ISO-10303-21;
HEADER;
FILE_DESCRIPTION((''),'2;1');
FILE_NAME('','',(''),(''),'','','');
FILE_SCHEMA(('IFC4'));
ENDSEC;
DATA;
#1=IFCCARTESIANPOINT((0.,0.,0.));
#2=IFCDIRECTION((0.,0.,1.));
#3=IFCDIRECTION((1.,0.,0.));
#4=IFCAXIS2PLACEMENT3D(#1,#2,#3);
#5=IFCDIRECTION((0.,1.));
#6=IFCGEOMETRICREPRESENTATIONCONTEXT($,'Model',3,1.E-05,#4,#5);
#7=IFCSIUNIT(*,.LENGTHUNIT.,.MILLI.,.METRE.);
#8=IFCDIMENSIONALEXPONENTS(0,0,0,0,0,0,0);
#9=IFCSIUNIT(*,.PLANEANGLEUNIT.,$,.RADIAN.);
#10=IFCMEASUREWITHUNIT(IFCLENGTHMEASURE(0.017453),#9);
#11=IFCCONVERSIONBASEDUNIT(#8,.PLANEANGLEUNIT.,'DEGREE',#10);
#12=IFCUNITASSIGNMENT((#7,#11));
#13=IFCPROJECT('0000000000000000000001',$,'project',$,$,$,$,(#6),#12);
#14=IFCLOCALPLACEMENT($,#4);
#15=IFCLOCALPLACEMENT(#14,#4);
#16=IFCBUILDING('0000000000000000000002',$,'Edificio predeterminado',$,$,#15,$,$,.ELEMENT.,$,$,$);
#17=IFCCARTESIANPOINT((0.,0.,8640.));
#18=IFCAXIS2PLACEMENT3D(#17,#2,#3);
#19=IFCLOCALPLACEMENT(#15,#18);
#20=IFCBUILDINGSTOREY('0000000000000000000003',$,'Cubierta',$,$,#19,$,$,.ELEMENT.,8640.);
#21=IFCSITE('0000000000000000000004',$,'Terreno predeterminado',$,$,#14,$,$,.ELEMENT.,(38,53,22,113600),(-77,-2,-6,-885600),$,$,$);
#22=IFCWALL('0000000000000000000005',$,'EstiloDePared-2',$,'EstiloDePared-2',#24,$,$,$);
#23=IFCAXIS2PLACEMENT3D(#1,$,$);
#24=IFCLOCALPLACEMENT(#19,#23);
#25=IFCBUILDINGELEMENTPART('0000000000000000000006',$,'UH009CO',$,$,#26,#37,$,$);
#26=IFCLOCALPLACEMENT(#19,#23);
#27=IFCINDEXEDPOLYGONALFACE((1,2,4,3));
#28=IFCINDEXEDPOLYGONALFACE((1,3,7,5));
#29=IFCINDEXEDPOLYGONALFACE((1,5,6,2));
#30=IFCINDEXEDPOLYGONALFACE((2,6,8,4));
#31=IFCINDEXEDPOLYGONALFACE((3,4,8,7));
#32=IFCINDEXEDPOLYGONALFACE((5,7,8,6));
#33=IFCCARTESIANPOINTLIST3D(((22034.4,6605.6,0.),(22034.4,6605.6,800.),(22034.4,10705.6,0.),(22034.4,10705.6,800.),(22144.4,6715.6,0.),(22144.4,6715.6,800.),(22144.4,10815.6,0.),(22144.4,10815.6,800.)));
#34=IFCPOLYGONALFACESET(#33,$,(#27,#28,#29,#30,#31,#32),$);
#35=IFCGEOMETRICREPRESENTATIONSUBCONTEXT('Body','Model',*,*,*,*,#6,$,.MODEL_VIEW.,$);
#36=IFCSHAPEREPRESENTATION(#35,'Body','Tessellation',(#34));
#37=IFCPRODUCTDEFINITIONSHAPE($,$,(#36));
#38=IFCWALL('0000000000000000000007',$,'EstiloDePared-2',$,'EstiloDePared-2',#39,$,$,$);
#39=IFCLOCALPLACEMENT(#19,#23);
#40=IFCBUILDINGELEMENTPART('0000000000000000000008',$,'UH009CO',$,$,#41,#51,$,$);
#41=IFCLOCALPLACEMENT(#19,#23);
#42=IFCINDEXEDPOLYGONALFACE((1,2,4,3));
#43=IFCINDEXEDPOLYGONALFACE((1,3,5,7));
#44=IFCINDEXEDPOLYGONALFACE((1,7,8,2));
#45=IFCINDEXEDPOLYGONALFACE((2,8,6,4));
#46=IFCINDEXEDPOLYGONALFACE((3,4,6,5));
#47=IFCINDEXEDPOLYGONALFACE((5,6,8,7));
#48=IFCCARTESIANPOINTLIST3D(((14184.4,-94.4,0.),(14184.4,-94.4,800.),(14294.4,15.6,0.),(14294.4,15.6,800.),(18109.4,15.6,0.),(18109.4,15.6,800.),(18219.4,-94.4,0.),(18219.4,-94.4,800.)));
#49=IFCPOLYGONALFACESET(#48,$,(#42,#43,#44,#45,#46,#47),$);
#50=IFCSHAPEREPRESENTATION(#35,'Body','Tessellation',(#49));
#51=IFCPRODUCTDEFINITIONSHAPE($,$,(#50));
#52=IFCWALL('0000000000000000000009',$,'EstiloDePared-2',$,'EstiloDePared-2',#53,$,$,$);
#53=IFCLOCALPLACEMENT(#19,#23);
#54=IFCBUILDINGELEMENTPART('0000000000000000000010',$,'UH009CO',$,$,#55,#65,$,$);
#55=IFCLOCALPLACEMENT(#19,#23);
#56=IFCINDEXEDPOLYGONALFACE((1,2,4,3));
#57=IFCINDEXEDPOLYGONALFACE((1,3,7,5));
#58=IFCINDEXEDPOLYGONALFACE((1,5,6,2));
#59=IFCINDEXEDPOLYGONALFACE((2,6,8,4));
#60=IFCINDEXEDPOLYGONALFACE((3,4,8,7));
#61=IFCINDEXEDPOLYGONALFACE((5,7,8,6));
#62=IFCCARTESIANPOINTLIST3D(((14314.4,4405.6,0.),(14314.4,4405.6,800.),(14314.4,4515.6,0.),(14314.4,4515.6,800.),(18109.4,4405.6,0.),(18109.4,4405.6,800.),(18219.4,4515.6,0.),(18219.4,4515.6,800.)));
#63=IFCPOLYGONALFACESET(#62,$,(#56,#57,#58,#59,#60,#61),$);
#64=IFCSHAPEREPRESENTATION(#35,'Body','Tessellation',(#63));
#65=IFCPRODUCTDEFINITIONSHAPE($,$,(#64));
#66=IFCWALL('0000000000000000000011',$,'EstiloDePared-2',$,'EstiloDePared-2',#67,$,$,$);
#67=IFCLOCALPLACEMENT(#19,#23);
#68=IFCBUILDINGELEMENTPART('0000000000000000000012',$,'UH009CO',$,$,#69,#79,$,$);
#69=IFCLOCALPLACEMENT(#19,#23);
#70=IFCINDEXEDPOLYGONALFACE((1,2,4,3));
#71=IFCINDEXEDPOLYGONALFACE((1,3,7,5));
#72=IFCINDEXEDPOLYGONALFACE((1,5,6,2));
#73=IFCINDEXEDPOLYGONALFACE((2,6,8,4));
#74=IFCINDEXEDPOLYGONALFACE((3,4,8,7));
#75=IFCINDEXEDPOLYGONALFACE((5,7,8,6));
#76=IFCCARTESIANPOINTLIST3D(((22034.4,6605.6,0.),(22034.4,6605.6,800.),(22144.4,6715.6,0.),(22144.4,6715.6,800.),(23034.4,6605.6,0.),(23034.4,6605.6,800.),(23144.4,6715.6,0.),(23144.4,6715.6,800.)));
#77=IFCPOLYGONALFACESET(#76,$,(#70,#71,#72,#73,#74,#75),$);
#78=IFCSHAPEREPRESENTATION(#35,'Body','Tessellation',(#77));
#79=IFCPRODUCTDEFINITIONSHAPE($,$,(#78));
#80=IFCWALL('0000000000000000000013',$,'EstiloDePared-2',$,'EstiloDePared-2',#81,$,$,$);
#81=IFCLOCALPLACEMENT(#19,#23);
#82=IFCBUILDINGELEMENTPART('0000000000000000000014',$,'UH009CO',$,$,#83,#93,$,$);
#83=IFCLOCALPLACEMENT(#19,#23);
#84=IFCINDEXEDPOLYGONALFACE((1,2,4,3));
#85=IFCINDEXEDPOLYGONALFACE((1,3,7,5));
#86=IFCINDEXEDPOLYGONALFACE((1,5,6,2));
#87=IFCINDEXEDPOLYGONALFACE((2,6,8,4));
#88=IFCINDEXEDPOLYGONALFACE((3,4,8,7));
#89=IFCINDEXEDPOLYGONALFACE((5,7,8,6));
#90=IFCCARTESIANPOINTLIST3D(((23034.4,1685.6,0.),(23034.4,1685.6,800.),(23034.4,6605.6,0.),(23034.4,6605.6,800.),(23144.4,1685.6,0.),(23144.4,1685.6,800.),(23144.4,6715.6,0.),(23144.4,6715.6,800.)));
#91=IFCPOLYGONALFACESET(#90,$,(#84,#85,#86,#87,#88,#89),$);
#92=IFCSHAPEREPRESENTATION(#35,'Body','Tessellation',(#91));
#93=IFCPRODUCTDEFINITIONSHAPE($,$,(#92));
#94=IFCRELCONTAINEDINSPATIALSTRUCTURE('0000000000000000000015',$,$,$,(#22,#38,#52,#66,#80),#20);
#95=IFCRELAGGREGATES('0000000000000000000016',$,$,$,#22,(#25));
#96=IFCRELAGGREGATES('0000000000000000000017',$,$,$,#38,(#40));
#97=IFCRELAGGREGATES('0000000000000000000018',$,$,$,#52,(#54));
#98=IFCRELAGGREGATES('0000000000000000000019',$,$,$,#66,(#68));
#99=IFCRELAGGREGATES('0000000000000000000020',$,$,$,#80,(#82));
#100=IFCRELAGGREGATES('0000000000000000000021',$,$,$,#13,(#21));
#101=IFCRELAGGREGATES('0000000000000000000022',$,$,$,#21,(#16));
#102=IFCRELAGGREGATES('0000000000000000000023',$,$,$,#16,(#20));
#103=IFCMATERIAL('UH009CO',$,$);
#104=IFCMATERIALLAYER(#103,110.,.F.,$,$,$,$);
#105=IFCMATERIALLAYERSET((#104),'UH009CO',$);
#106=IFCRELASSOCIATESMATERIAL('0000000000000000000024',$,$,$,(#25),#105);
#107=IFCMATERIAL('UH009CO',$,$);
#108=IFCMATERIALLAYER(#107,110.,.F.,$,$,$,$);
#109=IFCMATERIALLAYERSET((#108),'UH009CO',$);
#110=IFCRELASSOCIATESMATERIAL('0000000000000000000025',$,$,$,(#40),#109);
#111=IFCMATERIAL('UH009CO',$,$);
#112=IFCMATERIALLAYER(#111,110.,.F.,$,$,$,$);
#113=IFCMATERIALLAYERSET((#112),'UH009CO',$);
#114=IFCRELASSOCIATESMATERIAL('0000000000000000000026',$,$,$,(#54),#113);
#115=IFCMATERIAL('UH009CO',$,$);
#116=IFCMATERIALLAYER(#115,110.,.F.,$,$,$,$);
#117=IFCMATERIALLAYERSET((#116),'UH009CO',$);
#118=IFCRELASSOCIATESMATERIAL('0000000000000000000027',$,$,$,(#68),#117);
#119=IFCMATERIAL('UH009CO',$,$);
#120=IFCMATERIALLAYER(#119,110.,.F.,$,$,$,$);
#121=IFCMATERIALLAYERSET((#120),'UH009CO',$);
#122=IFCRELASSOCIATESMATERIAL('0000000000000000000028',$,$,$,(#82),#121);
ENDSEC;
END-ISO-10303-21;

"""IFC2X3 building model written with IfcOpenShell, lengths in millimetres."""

from ifc_helpers import new_model, entity, si_unit, converted_unit, direction, frame, origin_with_axes, place, context, subcontext, project, spatial, polyline, outline, extrude, material, layer, layer_set, layer_usage, element, aggregate, save


model = new_model("IFC2X3")

# Units and contexts
model_context = context("Model", 3, precision=1e-05, world=origin_with_axes(), true_north=direction((0.0, 1.0)))
body_context = subcontext(model_context, "Body", "Model", "MODEL_VIEW")
ifc_project = project(units=[si_unit("LENGTHUNIT", "METRE", prefix="MILLI"), converted_unit("PLANEANGLEUNIT", "DEGREE", entity("IfcLengthMeasure", 0.017453), si_unit("PLANEANGLEUNIT", "RADIAN"), dimensions=[0, 0, 0, 0, 0, 0, 0])], contexts=[model_context])

# Site, building, storey
site_placement = place(None, origin_with_axes())
site = spatial("IfcSite", under=ifc_project, at=site_placement, Name="Terreno predeterminado", CompositionType="ELEMENT", RefLatitude=(38, 53, 22, 113600), RefLongitude=(-77, -2, -6, -885600))
building_placement = place(site_placement, origin_with_axes())
building = spatial("IfcBuilding", under=site, at=building_placement, Name="Edificio predeterminado", CompositionType="ELEMENT")
storey_placement = place(building_placement, frame((0.0, 0.0, 8640.0), z_axis=(0.0, 0.0, 1.0), x_axis=(1.0, 0.0, 0.0)))
storey = spatial("IfcBuildingStorey", under=building, at=storey_placement, Name="Cubierta", CompositionType="ELEMENT", Elevation=8640.0)

# Wall, building element part
wall_1_placement = place(storey_placement, frame((22089.4, 10760.6, 0.0), z_axis=(0.0, 0.0, 1.0), x_axis=(0.0, -1.0, 0.0)))
wall_1 = element("IfcWall", 1, at=wall_1_placement, inside=storey, Name="EstiloDePared-2", ObjectType="EstiloDePared-2")
ifc_material_1 = material(Name="UH009CO")
ifc_layer_1 = layer(ifc_material_1, 110.0, ventilated=False)
ifc_layer_set_1 = layer_set([ifc_layer_1], Name="UH009CO")
ifc_layer_usage_1 = layer_usage(ifc_layer_set_1, "AXIS2", "NEGATIVE", -55.0)
building_element_part_1_placement = place(wall_1_placement, origin_with_axes())
building_element_part_1 = element("IfcBuildingElementPart", 2, at=building_element_part_1_placement, material=ifc_layer_usage_1, Name="UH009CO", context=body_context, shape_type="SweptSolid", body=[
    extrude(outline(polyline([(4045.0, 55.0), (4155.0, -55.0), (55.0, -55.0), (-55.0, 55.0), (4045.0, 55.0)])), origin_with_axes(), (0.0, 0.0, 1.0), 800.0),
])
aggregate(wall_1, [building_element_part_1])

# Walls, building element parts
wall_2_placement = place(storey_placement, frame((18164.4, -39.4, 0.0), z_axis=(0.0, 0.0, 1.0), x_axis=(-1.0, 0.0, 0.0)))
wall_2 = element("IfcWall", 3, at=wall_2_placement, inside=storey, Name="EstiloDePared-2", ObjectType="EstiloDePared-2")
ifc_material_2 = material(Name="UH009CO")
ifc_layer_2 = layer(ifc_material_2, 110.0, ventilated=False)
ifc_layer_set_2 = layer_set([ifc_layer_2], Name="UH009CO")
ifc_layer_usage_2 = layer_usage(ifc_layer_set_2, "AXIS2", "NEGATIVE", -55.0)
building_element_part_2_placement = place(wall_2_placement, origin_with_axes())
building_element_part_2 = element("IfcBuildingElementPart", 4, at=building_element_part_2_placement, material=ifc_layer_usage_2, Name="UH009CO", context=body_context, shape_type="SweptSolid", body=[
    extrude(outline(polyline([(3980.0, 55.0), (3870.0, -55.0), (55.0, -55.0), (-55.0, 55.0), (3980.0, 55.0)])), origin_with_axes(), (0.0, 0.0, 1.0), 800.0),
])
aggregate(wall_2, [building_element_part_2])
wall_3_placement = place(storey_placement, frame((18164.4, 4460.6, 0.0), z_axis=(0.0, 0.0, 1.0), x_axis=(-1.0, 0.0, 0.0)))
wall_3 = element("IfcWall", 5, at=wall_3_placement, inside=storey, Name="EstiloDePared-2", ObjectType="EstiloDePared-2")
ifc_material_3 = material(Name="UH009CO")
ifc_layer_3 = layer(ifc_material_3, 110.0, ventilated=False)
ifc_layer_set_3 = layer_set([ifc_layer_3], Name="UH009CO")
ifc_layer_usage_3 = layer_usage(ifc_layer_set_3, "AXIS2", "NEGATIVE", -55.0)
building_element_part_3_placement = place(wall_3_placement, origin_with_axes())
building_element_part_3 = element("IfcBuildingElementPart", 6, at=building_element_part_3_placement, material=ifc_layer_usage_3, Name="UH009CO", context=body_context, shape_type="SweptSolid", body=[
    extrude(outline(polyline([(3850.0, 55.0), (3850.0, -55.0), (-55.0, -55.0), (55.0, 55.0), (3850.0, 55.0)])), origin_with_axes(), (0.0, 0.0, 1.0), 800.0),
])
aggregate(wall_3, [building_element_part_3])
wall_4_placement = place(storey_placement, frame((22089.4, 6660.6, 0.0), z_axis=(0.0, 0.0, 1.0), x_axis=(1.0, 0.0, 0.0)))
wall_4 = element("IfcWall", 7, at=wall_4_placement, inside=storey, Name="EstiloDePared-2", ObjectType="EstiloDePared-2")
ifc_material_4 = material(Name="UH009CO")
ifc_layer_4 = layer(ifc_material_4, 110.0, ventilated=False)
ifc_layer_set_4 = layer_set([ifc_layer_4], Name="UH009CO")
ifc_layer_usage_4 = layer_usage(ifc_layer_set_4, "AXIS2", "NEGATIVE", -55.0)
building_element_part_4_placement = place(wall_4_placement, origin_with_axes())
building_element_part_4 = element("IfcBuildingElementPart", 8, at=building_element_part_4_placement, material=ifc_layer_usage_4, Name="UH009CO", context=body_context, shape_type="SweptSolid", body=[
    extrude(outline(polyline([(1055.0, 55.0), (945.0, -55.0), (-55.0, -55.0), (55.0, 55.0), (1055.0, 55.0)])), origin_with_axes(), (0.0, 0.0, 1.0), 800.0),
])
aggregate(wall_4, [building_element_part_4])
wall_5_placement = place(storey_placement, frame((23089.4, 6660.6, 0.0), z_axis=(0.0, 0.0, 1.0), x_axis=(0.0, -1.0, 0.0)))
wall_5 = element("IfcWall", 9, at=wall_5_placement, inside=storey, Name="EstiloDePared-2", ObjectType="EstiloDePared-2")
ifc_material_5 = material(Name="UH009CO")
ifc_layer_5 = layer(ifc_material_5, 110.0, ventilated=False)
ifc_layer_set_5 = layer_set([ifc_layer_5], Name="UH009CO")
ifc_layer_usage_5 = layer_usage(ifc_layer_set_5, "AXIS2", "NEGATIVE", -55.0)
building_element_part_5_placement = place(wall_5_placement, origin_with_axes())
building_element_part_5 = element("IfcBuildingElementPart", 10, at=building_element_part_5_placement, material=ifc_layer_usage_5, Name="UH009CO", context=body_context, shape_type="SweptSolid", body=[
    extrude(outline(polyline([(4975.0, 55.0), (4975.0, -55.0), (55.0, -55.0), (-55.0, 55.0), (4975.0, 55.0)])), origin_with_axes(), (0.0, 0.0, 1.0), 800.0),
])
aggregate(wall_5, [building_element_part_5])

save(model, "model.ifc")
